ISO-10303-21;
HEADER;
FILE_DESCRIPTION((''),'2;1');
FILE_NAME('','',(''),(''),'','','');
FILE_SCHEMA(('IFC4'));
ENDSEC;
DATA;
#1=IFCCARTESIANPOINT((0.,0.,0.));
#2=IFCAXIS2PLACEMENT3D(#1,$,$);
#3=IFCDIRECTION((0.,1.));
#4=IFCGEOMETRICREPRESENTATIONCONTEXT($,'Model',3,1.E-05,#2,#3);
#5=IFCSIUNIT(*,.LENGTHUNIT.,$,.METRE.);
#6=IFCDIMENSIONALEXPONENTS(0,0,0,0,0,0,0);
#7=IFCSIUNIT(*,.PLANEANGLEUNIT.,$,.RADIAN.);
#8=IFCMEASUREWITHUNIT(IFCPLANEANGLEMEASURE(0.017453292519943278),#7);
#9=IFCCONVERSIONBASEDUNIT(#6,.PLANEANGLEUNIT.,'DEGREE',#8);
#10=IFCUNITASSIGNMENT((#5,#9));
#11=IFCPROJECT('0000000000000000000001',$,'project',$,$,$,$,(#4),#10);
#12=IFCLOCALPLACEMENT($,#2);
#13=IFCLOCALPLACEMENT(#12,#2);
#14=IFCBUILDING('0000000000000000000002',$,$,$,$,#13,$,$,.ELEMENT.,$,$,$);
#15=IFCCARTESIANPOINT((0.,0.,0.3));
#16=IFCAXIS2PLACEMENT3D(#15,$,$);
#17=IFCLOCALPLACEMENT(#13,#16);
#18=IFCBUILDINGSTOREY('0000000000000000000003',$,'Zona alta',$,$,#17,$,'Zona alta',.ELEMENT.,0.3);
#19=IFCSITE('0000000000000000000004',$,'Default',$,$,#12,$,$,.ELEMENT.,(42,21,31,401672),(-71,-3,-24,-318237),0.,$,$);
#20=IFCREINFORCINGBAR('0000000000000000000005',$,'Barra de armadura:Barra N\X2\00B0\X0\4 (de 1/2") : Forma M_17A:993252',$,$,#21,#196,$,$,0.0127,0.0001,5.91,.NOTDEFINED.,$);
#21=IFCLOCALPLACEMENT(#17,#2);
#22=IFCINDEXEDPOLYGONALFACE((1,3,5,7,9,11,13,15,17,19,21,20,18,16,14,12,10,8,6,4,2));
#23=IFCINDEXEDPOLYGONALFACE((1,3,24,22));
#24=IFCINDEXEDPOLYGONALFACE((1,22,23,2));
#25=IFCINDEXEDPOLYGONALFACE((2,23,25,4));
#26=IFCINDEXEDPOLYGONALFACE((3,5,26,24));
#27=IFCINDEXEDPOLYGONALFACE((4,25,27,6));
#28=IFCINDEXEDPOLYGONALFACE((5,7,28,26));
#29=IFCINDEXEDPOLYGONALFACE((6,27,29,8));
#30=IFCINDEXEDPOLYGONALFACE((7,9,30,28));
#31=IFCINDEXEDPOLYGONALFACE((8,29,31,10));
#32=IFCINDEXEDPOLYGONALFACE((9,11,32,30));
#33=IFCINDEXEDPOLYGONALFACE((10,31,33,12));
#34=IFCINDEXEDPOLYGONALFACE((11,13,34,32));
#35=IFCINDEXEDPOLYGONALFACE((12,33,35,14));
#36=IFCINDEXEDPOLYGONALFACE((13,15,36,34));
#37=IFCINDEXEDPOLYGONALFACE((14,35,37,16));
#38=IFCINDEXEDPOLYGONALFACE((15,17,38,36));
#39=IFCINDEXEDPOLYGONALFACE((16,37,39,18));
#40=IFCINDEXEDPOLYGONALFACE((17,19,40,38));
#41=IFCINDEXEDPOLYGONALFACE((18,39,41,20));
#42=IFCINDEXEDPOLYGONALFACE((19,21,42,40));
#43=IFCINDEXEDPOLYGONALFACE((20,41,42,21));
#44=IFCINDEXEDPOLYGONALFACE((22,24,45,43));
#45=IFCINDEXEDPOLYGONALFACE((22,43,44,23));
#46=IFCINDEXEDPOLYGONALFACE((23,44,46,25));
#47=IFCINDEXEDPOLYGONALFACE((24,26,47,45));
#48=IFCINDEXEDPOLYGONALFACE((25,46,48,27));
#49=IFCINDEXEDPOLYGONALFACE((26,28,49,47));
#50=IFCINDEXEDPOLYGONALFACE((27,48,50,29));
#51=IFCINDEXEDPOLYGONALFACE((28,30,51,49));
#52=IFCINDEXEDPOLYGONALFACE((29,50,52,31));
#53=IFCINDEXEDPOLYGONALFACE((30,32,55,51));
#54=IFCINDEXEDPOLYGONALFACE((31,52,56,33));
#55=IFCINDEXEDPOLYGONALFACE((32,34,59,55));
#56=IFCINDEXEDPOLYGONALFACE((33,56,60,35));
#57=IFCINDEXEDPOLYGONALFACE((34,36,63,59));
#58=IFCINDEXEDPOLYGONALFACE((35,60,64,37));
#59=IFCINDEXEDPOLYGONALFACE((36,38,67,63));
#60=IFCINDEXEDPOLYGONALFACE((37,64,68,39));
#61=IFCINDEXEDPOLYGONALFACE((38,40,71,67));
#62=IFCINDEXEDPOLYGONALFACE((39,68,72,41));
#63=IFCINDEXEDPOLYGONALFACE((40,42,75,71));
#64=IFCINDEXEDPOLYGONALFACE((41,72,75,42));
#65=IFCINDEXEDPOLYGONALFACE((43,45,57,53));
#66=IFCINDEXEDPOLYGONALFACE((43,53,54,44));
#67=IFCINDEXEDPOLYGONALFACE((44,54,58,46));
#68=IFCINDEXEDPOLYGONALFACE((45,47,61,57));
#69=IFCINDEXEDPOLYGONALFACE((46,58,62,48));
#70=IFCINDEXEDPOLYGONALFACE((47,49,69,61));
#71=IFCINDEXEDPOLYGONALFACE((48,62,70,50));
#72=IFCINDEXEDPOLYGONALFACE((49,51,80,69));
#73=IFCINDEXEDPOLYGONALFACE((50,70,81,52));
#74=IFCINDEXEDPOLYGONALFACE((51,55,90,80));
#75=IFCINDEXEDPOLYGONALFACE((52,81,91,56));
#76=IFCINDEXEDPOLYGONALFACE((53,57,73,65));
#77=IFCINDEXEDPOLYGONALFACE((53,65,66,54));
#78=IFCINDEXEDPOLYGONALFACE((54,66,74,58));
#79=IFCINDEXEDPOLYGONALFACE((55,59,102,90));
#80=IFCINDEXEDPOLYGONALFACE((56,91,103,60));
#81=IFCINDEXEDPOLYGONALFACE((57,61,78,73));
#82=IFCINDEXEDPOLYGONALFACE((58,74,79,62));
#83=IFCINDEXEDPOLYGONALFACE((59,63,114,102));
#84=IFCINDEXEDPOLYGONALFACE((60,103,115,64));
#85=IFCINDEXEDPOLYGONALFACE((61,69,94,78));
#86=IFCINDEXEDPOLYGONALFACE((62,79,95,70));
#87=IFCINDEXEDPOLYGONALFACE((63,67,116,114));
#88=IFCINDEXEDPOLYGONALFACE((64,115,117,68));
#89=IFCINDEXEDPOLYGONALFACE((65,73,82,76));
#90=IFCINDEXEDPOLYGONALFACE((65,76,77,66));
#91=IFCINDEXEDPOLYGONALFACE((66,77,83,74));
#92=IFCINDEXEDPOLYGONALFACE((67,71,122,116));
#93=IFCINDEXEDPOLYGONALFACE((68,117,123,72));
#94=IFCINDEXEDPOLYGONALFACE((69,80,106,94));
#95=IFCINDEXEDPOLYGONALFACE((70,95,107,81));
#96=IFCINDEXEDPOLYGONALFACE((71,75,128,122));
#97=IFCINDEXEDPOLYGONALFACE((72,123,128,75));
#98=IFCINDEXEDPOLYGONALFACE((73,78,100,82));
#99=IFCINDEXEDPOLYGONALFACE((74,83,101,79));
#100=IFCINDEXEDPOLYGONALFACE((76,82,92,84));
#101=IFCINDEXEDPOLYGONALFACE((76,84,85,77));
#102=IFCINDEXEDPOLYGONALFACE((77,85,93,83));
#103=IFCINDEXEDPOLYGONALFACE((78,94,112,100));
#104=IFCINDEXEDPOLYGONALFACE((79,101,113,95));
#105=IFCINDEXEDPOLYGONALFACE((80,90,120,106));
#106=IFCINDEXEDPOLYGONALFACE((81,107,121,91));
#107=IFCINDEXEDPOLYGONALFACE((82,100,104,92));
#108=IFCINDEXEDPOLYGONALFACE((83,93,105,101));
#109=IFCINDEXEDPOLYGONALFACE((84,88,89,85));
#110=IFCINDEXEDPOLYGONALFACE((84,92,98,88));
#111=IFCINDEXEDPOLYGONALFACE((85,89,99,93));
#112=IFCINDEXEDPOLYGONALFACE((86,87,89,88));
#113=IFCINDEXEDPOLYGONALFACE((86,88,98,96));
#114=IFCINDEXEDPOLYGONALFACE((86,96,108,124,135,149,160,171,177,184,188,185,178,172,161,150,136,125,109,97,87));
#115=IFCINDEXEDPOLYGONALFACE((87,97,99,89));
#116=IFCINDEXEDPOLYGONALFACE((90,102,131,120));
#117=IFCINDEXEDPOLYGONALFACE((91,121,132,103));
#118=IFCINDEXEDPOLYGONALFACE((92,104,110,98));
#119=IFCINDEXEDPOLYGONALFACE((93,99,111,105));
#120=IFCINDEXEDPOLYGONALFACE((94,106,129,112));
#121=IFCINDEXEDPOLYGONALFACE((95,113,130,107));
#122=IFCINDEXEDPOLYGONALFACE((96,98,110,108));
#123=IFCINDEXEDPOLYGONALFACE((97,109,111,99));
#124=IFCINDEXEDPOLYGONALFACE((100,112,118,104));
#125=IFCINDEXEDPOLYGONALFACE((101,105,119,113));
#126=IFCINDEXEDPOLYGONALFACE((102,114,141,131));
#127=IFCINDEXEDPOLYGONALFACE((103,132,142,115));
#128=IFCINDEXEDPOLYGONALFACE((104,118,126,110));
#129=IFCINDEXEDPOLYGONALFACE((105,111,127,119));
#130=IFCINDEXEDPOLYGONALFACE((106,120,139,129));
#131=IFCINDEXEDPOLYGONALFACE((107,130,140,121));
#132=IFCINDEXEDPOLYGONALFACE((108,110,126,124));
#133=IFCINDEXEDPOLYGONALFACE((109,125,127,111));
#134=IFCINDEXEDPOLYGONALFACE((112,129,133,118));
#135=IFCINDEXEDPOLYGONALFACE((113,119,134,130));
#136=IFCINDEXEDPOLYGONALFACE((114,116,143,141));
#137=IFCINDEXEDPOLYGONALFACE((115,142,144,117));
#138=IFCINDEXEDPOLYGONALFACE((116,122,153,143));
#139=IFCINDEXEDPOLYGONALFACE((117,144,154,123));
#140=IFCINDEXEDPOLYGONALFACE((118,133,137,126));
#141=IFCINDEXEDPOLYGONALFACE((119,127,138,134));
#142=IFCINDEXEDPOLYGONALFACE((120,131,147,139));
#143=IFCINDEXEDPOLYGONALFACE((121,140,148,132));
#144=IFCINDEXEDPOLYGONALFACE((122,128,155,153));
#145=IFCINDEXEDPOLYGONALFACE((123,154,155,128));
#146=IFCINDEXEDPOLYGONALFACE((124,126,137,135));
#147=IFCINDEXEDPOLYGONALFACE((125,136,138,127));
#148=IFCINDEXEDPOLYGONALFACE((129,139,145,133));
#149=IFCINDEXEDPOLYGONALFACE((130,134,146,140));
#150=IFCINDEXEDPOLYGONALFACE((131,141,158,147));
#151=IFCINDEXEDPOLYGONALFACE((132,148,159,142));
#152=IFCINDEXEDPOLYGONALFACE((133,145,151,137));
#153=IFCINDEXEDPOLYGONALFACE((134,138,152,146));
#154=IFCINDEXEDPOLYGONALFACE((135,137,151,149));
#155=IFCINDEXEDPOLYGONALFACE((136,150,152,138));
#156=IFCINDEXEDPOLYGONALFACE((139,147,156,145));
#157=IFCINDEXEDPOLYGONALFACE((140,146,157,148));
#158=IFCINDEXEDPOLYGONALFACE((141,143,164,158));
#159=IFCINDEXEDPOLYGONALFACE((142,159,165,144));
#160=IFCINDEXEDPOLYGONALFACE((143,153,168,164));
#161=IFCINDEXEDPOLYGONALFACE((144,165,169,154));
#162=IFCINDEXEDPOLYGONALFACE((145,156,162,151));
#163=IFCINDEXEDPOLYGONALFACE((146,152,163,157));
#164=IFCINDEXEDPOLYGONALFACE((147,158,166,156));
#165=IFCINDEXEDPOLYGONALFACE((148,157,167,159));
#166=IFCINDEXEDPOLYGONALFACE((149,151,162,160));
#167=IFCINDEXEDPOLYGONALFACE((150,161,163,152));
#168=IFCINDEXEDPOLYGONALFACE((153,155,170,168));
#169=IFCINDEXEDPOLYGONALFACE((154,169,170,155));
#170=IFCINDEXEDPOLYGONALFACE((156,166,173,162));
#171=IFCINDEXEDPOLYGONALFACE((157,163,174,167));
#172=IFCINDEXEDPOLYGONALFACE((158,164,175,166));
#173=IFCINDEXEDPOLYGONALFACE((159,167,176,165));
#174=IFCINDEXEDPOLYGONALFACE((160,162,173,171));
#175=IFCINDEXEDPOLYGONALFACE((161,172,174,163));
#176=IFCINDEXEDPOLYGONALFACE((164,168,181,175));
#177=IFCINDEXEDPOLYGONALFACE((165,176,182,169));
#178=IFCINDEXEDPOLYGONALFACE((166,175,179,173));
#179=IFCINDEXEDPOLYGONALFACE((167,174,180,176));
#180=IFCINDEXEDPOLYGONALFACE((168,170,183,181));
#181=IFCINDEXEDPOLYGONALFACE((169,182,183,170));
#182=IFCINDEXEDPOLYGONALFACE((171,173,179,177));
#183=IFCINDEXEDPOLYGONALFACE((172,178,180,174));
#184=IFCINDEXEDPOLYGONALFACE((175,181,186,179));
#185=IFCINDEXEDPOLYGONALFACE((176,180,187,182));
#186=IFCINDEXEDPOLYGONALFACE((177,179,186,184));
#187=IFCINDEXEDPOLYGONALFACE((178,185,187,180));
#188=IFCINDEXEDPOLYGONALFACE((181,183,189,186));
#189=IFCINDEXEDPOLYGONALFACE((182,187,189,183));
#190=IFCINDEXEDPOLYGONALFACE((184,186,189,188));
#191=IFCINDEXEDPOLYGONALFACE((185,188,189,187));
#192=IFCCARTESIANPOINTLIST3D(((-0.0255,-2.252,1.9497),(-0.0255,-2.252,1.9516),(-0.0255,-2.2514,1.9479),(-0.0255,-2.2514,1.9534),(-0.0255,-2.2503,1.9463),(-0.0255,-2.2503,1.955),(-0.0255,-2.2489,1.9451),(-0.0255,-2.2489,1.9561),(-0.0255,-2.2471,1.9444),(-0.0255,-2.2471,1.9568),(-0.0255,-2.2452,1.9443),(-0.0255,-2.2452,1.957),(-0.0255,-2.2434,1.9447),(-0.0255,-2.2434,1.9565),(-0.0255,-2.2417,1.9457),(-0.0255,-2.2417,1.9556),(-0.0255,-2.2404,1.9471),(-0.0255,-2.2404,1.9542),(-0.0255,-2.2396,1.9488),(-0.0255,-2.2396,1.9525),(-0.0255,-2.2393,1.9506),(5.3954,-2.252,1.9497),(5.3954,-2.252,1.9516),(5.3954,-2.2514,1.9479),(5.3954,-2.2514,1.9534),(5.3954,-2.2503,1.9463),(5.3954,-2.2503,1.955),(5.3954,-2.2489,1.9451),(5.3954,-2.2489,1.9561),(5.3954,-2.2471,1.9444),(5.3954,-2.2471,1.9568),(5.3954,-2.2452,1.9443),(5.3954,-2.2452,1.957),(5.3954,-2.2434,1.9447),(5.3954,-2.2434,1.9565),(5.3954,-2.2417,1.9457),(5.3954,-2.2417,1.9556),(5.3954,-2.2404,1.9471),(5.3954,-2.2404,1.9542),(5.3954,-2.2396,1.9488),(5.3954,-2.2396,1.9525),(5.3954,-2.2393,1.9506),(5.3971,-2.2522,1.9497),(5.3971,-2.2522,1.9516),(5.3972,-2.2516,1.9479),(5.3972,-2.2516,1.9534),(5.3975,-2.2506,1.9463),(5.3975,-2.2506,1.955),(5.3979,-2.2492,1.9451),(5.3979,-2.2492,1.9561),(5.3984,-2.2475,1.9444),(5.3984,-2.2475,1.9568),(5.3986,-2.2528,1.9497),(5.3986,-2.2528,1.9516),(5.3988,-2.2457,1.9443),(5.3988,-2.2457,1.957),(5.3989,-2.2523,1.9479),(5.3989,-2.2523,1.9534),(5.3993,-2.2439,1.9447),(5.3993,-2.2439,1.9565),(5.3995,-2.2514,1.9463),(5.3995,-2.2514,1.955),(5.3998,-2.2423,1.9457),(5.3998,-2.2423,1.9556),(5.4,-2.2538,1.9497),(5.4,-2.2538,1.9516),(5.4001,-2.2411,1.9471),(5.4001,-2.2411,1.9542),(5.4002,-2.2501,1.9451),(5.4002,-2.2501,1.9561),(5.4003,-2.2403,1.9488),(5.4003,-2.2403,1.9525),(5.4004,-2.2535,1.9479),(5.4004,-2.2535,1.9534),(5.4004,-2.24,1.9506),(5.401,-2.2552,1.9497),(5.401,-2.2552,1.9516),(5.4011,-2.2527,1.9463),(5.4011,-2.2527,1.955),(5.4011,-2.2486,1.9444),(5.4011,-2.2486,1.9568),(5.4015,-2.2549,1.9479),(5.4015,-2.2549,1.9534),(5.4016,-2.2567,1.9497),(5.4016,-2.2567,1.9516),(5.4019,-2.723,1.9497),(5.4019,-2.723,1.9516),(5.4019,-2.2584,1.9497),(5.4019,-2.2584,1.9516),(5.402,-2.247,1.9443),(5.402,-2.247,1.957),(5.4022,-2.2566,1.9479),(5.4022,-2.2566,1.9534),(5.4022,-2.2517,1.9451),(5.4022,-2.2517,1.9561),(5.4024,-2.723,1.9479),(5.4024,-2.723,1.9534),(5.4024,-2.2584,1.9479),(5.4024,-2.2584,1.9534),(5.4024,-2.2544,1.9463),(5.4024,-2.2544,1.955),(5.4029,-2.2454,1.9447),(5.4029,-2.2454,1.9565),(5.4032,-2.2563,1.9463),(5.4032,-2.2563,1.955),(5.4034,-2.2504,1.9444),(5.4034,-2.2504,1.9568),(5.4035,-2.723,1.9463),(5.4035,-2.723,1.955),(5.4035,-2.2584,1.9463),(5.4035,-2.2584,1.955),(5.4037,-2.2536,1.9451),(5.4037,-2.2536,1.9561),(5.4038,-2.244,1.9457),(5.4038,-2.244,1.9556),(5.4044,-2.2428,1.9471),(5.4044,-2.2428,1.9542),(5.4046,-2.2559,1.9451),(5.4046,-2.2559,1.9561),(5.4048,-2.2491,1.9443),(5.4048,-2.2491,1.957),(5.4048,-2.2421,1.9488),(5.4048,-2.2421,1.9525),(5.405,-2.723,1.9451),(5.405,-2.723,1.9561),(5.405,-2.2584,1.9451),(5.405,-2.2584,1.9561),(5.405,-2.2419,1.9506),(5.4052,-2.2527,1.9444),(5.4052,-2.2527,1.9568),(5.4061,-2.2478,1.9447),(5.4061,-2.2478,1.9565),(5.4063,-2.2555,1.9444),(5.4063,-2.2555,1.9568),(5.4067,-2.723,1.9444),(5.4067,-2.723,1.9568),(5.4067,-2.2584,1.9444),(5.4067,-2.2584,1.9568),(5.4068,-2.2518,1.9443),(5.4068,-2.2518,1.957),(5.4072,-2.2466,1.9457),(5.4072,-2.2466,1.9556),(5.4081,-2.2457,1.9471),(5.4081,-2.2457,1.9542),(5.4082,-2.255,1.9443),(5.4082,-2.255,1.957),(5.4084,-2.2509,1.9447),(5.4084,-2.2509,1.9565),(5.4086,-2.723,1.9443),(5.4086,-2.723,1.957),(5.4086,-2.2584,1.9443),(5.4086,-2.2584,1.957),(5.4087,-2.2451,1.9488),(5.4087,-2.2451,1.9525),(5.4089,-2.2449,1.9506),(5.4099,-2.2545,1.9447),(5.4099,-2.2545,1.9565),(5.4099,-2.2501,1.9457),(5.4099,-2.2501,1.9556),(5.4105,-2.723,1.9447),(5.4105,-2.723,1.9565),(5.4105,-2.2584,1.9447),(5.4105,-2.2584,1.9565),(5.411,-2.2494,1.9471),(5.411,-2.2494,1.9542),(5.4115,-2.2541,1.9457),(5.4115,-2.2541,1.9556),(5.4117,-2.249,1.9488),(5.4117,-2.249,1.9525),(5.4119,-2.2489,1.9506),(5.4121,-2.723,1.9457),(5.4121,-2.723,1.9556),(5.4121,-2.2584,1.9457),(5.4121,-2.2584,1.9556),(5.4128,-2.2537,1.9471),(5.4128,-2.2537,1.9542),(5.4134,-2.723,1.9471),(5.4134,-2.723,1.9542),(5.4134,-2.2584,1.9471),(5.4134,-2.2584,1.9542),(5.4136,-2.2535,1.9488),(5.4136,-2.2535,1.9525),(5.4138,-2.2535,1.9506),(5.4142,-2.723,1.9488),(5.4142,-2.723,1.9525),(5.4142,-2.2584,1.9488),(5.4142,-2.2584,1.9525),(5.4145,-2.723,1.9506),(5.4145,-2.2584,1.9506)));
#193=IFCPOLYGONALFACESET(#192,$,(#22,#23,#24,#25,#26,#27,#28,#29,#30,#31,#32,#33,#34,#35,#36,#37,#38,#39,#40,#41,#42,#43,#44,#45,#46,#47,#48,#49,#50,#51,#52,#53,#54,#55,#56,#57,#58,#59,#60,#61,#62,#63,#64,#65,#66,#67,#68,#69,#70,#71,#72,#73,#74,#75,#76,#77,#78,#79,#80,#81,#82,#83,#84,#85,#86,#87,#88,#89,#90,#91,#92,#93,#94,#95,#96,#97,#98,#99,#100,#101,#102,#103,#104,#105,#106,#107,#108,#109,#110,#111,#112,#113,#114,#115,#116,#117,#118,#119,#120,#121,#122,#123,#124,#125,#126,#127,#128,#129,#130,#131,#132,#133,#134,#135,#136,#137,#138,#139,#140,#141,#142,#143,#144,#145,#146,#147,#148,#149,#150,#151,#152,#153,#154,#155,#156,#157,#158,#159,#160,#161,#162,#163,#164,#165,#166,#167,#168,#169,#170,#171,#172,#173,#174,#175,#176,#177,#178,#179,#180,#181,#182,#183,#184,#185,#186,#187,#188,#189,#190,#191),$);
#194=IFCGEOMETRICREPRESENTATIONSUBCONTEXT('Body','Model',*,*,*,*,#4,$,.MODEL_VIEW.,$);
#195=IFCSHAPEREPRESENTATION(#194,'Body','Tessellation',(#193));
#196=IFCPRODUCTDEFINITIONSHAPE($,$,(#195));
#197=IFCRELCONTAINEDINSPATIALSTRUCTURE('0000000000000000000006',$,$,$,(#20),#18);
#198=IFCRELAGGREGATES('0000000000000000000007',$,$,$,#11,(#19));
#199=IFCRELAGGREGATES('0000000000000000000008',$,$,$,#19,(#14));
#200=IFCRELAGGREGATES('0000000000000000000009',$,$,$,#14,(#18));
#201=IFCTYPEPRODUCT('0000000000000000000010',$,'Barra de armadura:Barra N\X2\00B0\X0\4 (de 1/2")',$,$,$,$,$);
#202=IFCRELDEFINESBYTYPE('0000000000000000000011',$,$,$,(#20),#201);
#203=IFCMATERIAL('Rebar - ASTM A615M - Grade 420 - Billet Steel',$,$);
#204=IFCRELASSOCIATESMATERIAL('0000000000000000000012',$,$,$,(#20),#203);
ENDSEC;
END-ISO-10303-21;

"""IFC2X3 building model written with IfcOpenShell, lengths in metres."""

from ifc_helpers import new_model, entity, si_unit, converted_unit, direction, frame, origin, place, context, subcontext, project, spatial, material, type_object, element, save


model = new_model("IFC2X3")

# Units and contexts
model_context = context("Model", 3, precision=1e-05, world=origin(), true_north=direction((0.0, 1.0)))
body_context = subcontext(model_context, "Body", "Model", "MODEL_VIEW")
ifc_project = project(units=[si_unit("LENGTHUNIT", "METRE"), converted_unit("PLANEANGLEUNIT", "DEGREE", entity("IfcPlaneAngleMeasure", 0.017453292519943278), si_unit("PLANEANGLEUNIT", "RADIAN"), dimensions=[0, 0, 0, 0, 0, 0, 0])], contexts=[model_context])

# Site, building, storey
site_placement = place(None, origin())
site = spatial("IfcSite", under=ifc_project, at=site_placement, Name="Default", CompositionType="ELEMENT", RefLatitude=(42, 21, 31, 401672), RefLongitude=(-71, -3, -24, -318237), RefElevation=0.0)
building_placement = place(site_placement, origin())
building = spatial("IfcBuilding", under=site, at=building_placement, CompositionType="ELEMENT")
storey_placement = place(building_placement, frame((0.0, 0.0, 0.3)))
storey = spatial("IfcBuildingStorey", under=building, at=storey_placement, Name="Zona alta", LongName="Zona alta", CompositionType="ELEMENT", Elevation=0.3)

# Reinforcing bar
ifc_material_1 = material(Name="Rebar - ASTM A615M - Grade 420 - Billet Steel")
type_product_1 = type_object("IfcTypeProduct", Name="Barra de armadura:Barra N°4 (de 1/2\")")
reinforcing_bar_1_placement = place(storey_placement, origin())
element("IfcReinforcingBar", 1, at=reinforcing_bar_1_placement, inside=storey, type_object=type_product_1, material=ifc_material_1, Name="Barra de armadura:Barra N°4 (de 1/2\") : Forma M_17A:993252", BarLength=5.91, BarRole="NOTDEFINED", CrossSectionArea=0.0001, NominalDiameter=0.0127, context=body_context, shape_type="AdvancedSweptSolid", body=[
    entity("IfcSweptDiskSolid", entity("IfcCompositeCurve", [entity("IfcCompositeCurveSegment", "CONTINUOUS", True, entity("IfcPolyline", [entity("IfcCartesianPoint", [-0.0255, -2.2457, 1.9506]), entity("IfcCartesianPoint", [5.3954, -2.2457, 1.9506])])), entity("IfcCompositeCurveSegment", "CONTINUOUS", True, entity("IfcTrimmedCurve", entity("IfcCircle", entity("IfcAxis2Placement3D", entity("IfcCartesianPoint", [5.3954, -2.2584, 1.9506]), entity("IfcDirection", [0.0, 0.0, -1.0]), entity("IfcDirection", [1.0, 0.0, 0.0])), 0.0127), [entity("IfcParameterValue", 270.0)], [entity("IfcParameterValue", 360.0)], True, "PARAMETER")), entity("IfcCompositeCurveSegment", "CONTINUOUS", True, entity("IfcPolyline", [entity("IfcCartesianPoint", [5.4081, -2.2584, 1.9506]), entity("IfcCartesianPoint", [5.4081, -2.723, 1.9506])]))], False), 0.0063, None, 0.0, 92.0),
])

save(model, "model.ifc")
